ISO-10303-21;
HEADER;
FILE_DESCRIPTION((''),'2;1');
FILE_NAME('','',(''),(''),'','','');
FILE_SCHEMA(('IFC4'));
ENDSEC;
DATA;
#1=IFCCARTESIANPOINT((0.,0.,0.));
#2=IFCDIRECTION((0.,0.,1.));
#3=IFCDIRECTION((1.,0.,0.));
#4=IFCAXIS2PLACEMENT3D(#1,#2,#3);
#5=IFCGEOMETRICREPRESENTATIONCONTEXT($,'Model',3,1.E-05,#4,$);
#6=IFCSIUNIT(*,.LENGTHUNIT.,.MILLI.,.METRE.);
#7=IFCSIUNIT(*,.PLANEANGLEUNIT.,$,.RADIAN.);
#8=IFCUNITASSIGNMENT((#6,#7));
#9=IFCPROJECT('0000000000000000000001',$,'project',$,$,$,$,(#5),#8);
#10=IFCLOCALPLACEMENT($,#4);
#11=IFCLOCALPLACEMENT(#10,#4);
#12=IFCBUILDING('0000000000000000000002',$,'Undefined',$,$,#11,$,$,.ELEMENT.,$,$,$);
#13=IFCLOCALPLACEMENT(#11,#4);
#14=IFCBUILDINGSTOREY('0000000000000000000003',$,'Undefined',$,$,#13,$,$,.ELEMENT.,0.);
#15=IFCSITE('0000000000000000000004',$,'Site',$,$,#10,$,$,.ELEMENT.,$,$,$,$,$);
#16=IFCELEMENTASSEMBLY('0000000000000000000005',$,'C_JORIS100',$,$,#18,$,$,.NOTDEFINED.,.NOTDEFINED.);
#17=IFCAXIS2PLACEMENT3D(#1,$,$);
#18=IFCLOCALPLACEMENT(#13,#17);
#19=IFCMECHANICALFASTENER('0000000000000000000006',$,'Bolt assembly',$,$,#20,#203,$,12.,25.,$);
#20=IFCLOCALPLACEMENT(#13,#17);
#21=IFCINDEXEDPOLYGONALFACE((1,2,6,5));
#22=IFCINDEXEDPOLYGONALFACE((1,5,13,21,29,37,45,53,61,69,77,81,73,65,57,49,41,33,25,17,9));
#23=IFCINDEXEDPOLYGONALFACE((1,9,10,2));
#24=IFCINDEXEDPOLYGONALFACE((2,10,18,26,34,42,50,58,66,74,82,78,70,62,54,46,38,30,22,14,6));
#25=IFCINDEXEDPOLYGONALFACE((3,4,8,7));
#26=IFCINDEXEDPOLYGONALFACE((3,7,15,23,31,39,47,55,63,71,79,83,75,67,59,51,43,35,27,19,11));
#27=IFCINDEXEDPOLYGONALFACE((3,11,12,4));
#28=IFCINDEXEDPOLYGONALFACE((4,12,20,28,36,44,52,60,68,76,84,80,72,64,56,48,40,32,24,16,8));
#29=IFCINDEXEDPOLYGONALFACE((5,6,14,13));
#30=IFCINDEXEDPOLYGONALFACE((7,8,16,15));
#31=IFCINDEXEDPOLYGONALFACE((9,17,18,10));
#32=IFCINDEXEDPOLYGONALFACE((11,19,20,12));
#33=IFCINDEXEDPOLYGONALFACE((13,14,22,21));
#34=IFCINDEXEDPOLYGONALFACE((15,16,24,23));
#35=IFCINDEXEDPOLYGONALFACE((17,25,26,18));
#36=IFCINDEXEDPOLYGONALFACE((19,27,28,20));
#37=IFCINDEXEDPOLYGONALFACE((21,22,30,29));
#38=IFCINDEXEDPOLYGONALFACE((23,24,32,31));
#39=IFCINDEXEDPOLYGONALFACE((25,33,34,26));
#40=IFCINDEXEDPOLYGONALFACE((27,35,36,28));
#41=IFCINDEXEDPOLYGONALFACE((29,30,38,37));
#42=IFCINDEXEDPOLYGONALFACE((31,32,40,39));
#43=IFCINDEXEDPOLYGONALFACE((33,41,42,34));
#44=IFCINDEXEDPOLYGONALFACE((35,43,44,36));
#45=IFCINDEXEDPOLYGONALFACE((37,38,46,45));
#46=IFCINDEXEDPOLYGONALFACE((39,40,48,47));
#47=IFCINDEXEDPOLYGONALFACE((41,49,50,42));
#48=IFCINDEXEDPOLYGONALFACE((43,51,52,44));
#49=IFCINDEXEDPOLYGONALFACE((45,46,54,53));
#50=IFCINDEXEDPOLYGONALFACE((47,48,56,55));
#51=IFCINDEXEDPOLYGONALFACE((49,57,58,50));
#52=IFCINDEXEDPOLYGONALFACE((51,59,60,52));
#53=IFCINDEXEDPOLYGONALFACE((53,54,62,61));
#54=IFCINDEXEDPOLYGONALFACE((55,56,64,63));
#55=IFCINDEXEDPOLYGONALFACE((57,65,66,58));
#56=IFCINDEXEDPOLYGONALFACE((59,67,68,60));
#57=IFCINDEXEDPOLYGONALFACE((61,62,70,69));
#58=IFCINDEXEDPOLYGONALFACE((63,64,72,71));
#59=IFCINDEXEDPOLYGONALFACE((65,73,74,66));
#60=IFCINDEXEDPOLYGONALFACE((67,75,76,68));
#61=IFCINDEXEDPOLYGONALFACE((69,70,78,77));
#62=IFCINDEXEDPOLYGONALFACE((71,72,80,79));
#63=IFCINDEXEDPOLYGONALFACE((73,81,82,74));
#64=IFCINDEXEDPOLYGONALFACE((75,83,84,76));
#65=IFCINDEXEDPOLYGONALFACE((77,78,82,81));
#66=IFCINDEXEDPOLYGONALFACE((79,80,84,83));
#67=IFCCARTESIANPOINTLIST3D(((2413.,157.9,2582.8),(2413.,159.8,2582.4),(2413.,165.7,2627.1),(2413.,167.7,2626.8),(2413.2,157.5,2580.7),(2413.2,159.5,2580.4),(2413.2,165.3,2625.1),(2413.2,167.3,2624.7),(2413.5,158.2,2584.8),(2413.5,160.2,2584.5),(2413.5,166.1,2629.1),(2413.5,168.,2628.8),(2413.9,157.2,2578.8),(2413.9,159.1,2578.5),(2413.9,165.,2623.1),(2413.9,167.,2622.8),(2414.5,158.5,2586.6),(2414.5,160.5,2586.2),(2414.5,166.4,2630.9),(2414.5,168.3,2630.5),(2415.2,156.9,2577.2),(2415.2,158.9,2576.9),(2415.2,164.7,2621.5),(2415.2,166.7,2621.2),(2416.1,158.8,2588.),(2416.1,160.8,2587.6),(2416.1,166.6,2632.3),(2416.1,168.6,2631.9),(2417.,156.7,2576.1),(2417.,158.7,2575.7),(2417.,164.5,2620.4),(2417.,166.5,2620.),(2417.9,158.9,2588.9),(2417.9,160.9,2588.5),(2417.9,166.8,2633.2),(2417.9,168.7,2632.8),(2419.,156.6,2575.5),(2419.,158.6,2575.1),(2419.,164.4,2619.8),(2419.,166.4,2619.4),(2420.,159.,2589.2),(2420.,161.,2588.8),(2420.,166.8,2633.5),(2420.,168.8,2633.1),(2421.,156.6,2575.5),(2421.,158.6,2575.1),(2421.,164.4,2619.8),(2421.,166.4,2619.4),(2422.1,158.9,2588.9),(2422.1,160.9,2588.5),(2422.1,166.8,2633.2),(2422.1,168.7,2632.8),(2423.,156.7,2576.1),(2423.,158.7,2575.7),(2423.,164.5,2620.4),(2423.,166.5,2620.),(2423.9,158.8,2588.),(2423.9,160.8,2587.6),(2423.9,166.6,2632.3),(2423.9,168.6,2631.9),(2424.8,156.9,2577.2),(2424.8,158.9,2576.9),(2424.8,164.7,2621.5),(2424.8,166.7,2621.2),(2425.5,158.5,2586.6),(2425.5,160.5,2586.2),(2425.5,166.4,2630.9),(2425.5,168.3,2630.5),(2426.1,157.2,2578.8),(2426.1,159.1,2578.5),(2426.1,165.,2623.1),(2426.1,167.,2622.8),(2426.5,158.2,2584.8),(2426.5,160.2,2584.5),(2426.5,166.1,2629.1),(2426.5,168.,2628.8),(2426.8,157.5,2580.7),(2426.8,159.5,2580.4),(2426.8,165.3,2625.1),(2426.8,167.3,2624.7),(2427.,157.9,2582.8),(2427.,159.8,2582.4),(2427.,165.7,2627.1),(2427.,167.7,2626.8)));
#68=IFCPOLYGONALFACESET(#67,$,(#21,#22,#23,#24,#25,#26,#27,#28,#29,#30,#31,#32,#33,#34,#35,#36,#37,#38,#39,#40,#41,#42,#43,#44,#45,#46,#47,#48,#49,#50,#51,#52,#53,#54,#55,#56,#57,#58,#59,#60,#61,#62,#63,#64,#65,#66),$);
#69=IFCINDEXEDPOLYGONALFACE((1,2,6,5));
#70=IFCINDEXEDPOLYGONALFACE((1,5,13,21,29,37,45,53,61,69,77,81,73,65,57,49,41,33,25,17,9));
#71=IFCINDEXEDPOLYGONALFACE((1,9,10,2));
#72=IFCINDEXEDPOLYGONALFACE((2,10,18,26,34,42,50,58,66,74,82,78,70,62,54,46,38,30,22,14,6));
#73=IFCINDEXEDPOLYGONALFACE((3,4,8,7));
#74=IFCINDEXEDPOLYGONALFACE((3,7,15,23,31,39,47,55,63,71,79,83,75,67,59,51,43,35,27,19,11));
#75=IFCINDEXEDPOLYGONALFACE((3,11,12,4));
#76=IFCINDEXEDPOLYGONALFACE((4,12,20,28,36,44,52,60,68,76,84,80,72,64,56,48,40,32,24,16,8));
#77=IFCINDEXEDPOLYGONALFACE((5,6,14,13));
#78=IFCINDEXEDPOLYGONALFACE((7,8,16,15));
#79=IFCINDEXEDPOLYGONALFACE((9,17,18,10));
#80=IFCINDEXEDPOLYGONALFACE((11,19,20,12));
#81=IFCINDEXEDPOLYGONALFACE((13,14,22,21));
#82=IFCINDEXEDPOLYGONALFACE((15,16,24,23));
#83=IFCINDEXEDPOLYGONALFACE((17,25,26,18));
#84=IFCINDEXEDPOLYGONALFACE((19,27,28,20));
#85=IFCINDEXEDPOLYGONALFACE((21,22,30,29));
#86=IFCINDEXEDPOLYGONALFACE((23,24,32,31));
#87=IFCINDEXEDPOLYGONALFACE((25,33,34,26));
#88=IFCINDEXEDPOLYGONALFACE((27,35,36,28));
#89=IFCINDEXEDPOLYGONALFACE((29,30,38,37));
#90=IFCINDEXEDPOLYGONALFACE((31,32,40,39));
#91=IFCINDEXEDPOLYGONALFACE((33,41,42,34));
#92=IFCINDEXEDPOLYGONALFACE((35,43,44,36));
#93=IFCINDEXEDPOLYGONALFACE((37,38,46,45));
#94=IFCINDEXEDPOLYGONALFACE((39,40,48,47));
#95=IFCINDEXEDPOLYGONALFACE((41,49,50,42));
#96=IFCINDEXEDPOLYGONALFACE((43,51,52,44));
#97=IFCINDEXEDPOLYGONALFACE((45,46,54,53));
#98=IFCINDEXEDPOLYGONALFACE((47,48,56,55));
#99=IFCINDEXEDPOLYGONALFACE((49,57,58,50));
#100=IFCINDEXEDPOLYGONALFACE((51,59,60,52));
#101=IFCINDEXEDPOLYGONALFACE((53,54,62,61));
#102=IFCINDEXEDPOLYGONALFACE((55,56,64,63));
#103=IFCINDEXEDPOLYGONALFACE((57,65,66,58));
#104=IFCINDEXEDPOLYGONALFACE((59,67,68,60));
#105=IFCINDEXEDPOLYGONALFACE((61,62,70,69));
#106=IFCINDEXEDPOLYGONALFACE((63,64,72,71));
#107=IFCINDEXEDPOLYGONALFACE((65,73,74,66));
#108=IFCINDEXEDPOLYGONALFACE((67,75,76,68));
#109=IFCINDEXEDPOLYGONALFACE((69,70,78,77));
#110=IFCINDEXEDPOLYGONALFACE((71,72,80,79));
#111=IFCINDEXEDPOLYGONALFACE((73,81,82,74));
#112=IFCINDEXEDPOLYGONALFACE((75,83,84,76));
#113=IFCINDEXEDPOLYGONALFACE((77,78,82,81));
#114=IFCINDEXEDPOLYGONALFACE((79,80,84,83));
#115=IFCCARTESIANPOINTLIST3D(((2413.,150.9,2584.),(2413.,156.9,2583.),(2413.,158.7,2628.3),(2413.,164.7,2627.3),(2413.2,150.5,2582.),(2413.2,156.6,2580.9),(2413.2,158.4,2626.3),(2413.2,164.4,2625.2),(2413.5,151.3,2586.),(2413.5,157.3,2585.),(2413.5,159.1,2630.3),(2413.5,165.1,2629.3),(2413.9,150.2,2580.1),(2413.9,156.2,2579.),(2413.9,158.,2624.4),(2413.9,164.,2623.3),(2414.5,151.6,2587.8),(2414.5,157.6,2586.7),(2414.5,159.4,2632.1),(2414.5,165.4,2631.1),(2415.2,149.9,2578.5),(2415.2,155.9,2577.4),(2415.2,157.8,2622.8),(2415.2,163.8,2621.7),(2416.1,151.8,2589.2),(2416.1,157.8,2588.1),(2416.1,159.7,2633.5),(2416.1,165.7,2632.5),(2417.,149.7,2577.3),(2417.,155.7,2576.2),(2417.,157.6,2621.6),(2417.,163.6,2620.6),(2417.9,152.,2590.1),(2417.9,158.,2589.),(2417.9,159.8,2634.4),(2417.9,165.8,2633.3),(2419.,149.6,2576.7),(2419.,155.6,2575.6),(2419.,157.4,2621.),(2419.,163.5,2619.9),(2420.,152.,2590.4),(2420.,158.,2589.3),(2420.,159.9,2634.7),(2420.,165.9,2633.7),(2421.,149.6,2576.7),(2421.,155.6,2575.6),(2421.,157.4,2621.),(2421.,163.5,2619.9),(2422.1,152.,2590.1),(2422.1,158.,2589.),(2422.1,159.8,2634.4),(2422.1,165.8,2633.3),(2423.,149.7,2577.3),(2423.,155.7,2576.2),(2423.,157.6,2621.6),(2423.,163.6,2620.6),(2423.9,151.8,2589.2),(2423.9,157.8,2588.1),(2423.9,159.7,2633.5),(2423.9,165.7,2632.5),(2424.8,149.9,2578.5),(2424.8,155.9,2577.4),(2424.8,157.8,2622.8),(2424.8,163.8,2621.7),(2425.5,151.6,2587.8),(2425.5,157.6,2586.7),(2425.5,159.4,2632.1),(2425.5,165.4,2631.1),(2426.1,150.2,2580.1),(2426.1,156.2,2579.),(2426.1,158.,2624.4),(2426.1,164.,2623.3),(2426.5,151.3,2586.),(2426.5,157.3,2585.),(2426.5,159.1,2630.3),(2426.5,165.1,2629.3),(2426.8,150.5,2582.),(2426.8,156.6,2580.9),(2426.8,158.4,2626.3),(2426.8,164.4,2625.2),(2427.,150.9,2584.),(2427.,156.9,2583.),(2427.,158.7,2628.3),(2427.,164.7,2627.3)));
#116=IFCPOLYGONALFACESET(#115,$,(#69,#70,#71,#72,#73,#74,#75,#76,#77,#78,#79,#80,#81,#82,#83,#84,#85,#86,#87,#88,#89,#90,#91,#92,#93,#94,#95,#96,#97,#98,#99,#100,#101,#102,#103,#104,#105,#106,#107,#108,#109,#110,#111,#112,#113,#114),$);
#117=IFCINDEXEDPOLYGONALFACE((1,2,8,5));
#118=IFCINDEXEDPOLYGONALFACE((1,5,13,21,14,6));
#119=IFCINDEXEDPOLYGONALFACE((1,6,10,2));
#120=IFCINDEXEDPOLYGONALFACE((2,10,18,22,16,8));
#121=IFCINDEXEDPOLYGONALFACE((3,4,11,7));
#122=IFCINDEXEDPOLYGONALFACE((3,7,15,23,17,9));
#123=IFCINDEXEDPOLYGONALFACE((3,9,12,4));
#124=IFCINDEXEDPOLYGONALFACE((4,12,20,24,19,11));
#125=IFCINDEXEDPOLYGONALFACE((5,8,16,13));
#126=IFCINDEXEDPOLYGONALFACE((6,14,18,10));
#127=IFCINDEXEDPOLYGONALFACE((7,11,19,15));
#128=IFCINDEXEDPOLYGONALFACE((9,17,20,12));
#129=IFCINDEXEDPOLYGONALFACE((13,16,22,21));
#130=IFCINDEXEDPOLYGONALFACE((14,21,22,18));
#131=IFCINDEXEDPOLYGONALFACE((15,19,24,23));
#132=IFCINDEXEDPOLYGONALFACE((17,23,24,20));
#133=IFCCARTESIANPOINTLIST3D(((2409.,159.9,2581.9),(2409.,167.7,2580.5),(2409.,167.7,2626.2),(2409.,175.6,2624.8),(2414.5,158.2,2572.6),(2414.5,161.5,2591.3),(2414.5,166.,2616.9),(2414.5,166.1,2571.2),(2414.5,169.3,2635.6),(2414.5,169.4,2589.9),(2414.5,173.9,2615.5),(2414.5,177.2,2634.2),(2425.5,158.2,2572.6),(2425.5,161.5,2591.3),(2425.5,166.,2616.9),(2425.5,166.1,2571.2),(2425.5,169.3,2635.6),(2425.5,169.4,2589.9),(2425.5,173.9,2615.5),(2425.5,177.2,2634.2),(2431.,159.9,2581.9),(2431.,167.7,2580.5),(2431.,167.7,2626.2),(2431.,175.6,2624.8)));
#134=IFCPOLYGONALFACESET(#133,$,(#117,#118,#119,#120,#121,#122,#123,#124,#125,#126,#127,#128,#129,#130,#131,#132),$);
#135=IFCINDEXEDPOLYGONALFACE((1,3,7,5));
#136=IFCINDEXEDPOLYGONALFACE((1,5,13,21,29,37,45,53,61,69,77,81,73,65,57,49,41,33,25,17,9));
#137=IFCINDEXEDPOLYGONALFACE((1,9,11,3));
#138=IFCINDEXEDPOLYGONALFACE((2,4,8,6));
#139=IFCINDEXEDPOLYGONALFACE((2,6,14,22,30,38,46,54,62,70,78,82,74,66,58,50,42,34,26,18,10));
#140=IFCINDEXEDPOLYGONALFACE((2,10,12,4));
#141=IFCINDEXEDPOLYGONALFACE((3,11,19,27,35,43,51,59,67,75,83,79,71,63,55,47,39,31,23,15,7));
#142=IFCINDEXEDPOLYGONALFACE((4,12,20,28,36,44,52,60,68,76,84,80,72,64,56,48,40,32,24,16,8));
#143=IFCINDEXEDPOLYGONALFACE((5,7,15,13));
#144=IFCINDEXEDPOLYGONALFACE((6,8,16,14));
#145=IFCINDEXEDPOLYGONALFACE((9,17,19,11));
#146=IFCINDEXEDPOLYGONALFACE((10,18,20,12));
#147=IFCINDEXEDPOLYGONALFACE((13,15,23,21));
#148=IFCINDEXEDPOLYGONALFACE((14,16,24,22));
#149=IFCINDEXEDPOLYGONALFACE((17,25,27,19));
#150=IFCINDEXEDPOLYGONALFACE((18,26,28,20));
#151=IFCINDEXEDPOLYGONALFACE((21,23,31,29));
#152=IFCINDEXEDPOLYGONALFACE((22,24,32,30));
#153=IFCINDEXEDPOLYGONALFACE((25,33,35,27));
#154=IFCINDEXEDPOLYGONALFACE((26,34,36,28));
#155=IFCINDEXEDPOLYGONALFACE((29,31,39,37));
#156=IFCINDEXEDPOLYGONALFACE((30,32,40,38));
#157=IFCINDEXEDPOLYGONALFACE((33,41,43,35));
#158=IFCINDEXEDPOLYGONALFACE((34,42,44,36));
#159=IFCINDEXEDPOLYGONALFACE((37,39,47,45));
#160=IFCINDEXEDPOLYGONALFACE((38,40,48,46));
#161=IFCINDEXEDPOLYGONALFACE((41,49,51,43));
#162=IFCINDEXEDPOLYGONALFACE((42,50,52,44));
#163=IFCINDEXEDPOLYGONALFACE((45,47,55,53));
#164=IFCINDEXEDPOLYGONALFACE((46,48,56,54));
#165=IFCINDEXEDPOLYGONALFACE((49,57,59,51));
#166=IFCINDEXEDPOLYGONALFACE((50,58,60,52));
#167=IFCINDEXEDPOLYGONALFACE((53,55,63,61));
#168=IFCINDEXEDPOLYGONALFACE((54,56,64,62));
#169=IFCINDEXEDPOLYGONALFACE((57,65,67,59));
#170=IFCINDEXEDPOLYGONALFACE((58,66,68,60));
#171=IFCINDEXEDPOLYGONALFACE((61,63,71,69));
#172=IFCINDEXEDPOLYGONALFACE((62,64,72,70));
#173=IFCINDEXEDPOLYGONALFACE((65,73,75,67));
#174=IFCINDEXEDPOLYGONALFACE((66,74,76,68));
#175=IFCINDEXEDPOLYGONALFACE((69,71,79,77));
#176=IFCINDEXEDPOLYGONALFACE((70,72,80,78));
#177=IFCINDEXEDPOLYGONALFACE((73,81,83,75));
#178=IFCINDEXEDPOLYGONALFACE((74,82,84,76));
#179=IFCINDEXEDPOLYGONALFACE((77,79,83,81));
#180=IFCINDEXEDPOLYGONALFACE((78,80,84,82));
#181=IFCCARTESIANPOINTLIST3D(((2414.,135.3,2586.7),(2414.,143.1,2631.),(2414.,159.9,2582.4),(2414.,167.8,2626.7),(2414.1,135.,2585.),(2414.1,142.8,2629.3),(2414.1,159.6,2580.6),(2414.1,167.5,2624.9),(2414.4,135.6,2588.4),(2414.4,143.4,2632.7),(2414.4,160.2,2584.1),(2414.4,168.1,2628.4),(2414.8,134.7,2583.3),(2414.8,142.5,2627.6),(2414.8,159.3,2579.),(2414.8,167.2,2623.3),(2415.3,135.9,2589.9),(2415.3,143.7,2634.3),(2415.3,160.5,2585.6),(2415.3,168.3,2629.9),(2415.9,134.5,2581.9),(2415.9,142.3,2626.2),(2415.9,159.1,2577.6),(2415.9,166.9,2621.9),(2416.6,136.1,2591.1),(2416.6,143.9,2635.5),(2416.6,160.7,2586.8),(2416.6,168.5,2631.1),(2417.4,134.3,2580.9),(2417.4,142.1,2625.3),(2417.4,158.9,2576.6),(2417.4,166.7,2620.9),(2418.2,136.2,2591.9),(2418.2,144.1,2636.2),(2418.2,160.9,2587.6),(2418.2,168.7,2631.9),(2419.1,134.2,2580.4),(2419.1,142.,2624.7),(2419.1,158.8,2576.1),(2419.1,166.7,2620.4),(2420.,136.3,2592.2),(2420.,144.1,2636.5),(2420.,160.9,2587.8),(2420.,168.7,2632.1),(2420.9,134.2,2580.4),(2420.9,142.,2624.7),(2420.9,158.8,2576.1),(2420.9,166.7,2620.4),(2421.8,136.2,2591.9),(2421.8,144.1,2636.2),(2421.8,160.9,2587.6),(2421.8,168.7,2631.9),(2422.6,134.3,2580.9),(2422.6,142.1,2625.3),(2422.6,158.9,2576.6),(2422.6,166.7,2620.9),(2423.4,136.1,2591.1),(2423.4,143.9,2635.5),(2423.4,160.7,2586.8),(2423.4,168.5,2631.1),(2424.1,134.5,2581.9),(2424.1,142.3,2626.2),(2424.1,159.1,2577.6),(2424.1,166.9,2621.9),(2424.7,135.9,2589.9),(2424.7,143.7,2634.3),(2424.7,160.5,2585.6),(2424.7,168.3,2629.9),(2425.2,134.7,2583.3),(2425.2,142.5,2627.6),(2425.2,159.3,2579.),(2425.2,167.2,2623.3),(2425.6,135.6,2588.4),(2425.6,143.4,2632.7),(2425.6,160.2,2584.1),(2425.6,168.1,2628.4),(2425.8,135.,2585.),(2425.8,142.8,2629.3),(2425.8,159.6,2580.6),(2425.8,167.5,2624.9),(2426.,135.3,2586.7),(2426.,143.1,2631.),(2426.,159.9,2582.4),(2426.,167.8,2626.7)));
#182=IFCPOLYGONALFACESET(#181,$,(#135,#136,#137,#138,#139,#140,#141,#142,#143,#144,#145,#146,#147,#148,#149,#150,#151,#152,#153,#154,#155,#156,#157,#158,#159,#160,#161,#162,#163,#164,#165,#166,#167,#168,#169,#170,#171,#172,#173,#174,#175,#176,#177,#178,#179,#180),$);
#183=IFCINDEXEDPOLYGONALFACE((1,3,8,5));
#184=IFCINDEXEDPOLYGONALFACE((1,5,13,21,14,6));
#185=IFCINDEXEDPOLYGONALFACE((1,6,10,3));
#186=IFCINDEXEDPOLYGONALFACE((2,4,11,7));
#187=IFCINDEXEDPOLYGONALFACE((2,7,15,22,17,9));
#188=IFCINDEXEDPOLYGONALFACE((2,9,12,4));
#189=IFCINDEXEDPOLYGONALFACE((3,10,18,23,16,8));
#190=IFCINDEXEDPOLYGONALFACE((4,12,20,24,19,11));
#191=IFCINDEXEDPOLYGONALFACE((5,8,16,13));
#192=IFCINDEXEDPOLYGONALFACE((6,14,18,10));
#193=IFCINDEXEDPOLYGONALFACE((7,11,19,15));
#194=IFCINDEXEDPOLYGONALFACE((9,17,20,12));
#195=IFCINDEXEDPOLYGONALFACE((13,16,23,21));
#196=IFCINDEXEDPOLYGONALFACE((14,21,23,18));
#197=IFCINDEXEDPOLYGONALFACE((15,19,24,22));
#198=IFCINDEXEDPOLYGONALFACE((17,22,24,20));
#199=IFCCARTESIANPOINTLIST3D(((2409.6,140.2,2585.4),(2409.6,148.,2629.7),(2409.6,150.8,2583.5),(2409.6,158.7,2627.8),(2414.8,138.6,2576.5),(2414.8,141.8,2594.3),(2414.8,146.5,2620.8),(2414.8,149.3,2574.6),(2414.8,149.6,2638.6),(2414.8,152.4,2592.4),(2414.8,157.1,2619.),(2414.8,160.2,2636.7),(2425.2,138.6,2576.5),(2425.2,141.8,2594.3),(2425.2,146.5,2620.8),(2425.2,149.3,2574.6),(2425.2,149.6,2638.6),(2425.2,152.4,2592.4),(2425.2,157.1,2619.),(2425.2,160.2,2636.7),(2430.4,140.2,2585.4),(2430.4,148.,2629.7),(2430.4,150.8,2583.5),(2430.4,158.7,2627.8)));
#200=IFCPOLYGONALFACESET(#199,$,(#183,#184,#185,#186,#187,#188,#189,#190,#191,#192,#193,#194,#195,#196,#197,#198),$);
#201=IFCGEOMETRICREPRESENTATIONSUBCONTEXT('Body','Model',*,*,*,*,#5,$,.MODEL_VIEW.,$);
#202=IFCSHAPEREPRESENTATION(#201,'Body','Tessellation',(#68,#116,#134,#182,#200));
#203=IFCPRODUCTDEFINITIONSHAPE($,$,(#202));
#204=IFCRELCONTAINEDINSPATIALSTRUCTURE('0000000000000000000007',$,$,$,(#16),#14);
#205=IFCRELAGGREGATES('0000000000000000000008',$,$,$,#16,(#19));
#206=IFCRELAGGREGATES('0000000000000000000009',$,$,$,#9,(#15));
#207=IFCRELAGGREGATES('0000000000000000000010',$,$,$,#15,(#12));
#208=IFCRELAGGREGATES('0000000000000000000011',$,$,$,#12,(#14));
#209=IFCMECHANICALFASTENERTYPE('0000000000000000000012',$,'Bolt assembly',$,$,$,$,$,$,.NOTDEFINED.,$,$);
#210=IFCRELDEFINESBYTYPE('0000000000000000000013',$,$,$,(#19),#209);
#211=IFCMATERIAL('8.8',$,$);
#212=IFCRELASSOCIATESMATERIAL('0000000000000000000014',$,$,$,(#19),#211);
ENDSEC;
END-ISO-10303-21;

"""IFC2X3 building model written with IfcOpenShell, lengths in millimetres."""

from ifc_helpers import new_model, si_unit, frame, origin_with_axes, origin_2d_with_axis, place, context, subcontext, project, spatial, polyline, circle, outline, extrude, source, transform, mapped, material, type_object, element, aggregate, save


model = new_model("IFC2X3")

# Units and contexts
model_context = context("Model", 3, precision=1e-05, world=origin_with_axes())
body_context = subcontext(model_context, "Body", "Model", "MODEL_VIEW")
ifc_project = project(units=[si_unit("LENGTHUNIT", "METRE", prefix="MILLI"), si_unit("PLANEANGLEUNIT", "RADIAN")], contexts=[model_context])

# Site, building, storey
site_placement = place(None, origin_with_axes())
site = spatial("IfcSite", under=ifc_project, at=site_placement, Name="Site", CompositionType="ELEMENT")
building_placement = place(site_placement, origin_with_axes())
building = spatial("IfcBuilding", under=site, at=building_placement, Name="Undefined", CompositionType="ELEMENT")
storey_placement = place(building_placement, origin_with_axes())
storey = spatial("IfcBuildingStorey", under=building, at=storey_placement, Name="Undefined", CompositionType="ELEMENT", Elevation=0.0)

# Element assembly
assembly_1_placement = place(storey_placement, origin_with_axes())
assembly_1 = element("IfcElementAssembly", 1, at=assembly_1_placement, inside=storey, Name="C_JORIS100", AssemblyPlace="NOTDEFINED", PredefinedType="NOTDEFINED")

# Shared definitions
ifc_material_1 = material(Name="8.8")
mechanical_fastener_type = type_object("IfcMechanicalFastenerType", Name="Bolt assembly")

# Mechanical fastener
shared_shape_1 = source(origin_with_axes(), body_context, "Body", "SweptSolid", [
    extrude(circle(Radius=7.0, at=origin_2d_with_axis()), frame((0.0, -6.1, 0.0), z_axis=(0.0, 1.0, 0.0), x_axis=(1.0, 0.0, 0.0)), (0.0, 0.0, 1.0), 2.0),
    extrude(circle(Radius=7.0, at=origin_2d_with_axis()), frame((0.0, -3.1, 0.0), z_axis=(0.0, 1.0, 0.0), x_axis=(1.0, 0.0, 0.0)), (0.0, 0.0, 1.0), 6.1),
    extrude(outline(polyline([(9.5, -5.5), (9.5, 5.5), (0.0, 11.0), (-9.5, 5.5), (-9.5, -5.5), (0.0, -11.0), (9.5, -5.5)])), frame((0.0, -14.2, 0.0), z_axis=(0.0, 1.0, 0.0), x_axis=(1.0, 0.0, 0.0)), (0.0, 0.0, 1.0), 8.0),
    extrude(circle(Radius=6.0, at=origin_2d_with_axis()), frame((0.0, -6.2, 0.0), z_axis=(0.0, 1.0, 0.0), x_axis=(1.0, 0.0, 0.0)), (0.0, 0.0, 1.0), 25.0),
    extrude(outline(polyline([(9.0, -5.2), (9.0, 5.2), (0.0, 10.4), (-9.0, 5.2), (-9.0, -5.2), (0.0, -10.4), (9.0, -5.2)])), frame((0.0, 3.0, 0.0), z_axis=(0.0, 1.0, 0.0), x_axis=(1.0, 0.0, 0.0)), (0.0, 0.0, 1.0), 10.8),
])
mechanical_fastener_1_placement = place(assembly_1_placement, frame((2420.0, 153.8, 2583.0), z_axis=(1.0, 0.0, 0.0), x_axis=(0.0, 0.174019, 0.984742)))
mechanical_fastener_1 = element("IfcMechanicalFastener", 2, at=mechanical_fastener_1_placement, type_object=mechanical_fastener_type, material=ifc_material_1, Name="Bolt assembly", NominalDiameter=12.0, NominalLength=25.0, context=body_context, shape_type="MappedRepresentation", body=[
    mapped(shared_shape_1, transform((0.0, 0.0, 0.0))),
    mapped(shared_shape_1, transform((45.0, 0.0, 0.0))),
])
aggregate(assembly_1, [mechanical_fastener_1])

save(model, "model.ifc")
